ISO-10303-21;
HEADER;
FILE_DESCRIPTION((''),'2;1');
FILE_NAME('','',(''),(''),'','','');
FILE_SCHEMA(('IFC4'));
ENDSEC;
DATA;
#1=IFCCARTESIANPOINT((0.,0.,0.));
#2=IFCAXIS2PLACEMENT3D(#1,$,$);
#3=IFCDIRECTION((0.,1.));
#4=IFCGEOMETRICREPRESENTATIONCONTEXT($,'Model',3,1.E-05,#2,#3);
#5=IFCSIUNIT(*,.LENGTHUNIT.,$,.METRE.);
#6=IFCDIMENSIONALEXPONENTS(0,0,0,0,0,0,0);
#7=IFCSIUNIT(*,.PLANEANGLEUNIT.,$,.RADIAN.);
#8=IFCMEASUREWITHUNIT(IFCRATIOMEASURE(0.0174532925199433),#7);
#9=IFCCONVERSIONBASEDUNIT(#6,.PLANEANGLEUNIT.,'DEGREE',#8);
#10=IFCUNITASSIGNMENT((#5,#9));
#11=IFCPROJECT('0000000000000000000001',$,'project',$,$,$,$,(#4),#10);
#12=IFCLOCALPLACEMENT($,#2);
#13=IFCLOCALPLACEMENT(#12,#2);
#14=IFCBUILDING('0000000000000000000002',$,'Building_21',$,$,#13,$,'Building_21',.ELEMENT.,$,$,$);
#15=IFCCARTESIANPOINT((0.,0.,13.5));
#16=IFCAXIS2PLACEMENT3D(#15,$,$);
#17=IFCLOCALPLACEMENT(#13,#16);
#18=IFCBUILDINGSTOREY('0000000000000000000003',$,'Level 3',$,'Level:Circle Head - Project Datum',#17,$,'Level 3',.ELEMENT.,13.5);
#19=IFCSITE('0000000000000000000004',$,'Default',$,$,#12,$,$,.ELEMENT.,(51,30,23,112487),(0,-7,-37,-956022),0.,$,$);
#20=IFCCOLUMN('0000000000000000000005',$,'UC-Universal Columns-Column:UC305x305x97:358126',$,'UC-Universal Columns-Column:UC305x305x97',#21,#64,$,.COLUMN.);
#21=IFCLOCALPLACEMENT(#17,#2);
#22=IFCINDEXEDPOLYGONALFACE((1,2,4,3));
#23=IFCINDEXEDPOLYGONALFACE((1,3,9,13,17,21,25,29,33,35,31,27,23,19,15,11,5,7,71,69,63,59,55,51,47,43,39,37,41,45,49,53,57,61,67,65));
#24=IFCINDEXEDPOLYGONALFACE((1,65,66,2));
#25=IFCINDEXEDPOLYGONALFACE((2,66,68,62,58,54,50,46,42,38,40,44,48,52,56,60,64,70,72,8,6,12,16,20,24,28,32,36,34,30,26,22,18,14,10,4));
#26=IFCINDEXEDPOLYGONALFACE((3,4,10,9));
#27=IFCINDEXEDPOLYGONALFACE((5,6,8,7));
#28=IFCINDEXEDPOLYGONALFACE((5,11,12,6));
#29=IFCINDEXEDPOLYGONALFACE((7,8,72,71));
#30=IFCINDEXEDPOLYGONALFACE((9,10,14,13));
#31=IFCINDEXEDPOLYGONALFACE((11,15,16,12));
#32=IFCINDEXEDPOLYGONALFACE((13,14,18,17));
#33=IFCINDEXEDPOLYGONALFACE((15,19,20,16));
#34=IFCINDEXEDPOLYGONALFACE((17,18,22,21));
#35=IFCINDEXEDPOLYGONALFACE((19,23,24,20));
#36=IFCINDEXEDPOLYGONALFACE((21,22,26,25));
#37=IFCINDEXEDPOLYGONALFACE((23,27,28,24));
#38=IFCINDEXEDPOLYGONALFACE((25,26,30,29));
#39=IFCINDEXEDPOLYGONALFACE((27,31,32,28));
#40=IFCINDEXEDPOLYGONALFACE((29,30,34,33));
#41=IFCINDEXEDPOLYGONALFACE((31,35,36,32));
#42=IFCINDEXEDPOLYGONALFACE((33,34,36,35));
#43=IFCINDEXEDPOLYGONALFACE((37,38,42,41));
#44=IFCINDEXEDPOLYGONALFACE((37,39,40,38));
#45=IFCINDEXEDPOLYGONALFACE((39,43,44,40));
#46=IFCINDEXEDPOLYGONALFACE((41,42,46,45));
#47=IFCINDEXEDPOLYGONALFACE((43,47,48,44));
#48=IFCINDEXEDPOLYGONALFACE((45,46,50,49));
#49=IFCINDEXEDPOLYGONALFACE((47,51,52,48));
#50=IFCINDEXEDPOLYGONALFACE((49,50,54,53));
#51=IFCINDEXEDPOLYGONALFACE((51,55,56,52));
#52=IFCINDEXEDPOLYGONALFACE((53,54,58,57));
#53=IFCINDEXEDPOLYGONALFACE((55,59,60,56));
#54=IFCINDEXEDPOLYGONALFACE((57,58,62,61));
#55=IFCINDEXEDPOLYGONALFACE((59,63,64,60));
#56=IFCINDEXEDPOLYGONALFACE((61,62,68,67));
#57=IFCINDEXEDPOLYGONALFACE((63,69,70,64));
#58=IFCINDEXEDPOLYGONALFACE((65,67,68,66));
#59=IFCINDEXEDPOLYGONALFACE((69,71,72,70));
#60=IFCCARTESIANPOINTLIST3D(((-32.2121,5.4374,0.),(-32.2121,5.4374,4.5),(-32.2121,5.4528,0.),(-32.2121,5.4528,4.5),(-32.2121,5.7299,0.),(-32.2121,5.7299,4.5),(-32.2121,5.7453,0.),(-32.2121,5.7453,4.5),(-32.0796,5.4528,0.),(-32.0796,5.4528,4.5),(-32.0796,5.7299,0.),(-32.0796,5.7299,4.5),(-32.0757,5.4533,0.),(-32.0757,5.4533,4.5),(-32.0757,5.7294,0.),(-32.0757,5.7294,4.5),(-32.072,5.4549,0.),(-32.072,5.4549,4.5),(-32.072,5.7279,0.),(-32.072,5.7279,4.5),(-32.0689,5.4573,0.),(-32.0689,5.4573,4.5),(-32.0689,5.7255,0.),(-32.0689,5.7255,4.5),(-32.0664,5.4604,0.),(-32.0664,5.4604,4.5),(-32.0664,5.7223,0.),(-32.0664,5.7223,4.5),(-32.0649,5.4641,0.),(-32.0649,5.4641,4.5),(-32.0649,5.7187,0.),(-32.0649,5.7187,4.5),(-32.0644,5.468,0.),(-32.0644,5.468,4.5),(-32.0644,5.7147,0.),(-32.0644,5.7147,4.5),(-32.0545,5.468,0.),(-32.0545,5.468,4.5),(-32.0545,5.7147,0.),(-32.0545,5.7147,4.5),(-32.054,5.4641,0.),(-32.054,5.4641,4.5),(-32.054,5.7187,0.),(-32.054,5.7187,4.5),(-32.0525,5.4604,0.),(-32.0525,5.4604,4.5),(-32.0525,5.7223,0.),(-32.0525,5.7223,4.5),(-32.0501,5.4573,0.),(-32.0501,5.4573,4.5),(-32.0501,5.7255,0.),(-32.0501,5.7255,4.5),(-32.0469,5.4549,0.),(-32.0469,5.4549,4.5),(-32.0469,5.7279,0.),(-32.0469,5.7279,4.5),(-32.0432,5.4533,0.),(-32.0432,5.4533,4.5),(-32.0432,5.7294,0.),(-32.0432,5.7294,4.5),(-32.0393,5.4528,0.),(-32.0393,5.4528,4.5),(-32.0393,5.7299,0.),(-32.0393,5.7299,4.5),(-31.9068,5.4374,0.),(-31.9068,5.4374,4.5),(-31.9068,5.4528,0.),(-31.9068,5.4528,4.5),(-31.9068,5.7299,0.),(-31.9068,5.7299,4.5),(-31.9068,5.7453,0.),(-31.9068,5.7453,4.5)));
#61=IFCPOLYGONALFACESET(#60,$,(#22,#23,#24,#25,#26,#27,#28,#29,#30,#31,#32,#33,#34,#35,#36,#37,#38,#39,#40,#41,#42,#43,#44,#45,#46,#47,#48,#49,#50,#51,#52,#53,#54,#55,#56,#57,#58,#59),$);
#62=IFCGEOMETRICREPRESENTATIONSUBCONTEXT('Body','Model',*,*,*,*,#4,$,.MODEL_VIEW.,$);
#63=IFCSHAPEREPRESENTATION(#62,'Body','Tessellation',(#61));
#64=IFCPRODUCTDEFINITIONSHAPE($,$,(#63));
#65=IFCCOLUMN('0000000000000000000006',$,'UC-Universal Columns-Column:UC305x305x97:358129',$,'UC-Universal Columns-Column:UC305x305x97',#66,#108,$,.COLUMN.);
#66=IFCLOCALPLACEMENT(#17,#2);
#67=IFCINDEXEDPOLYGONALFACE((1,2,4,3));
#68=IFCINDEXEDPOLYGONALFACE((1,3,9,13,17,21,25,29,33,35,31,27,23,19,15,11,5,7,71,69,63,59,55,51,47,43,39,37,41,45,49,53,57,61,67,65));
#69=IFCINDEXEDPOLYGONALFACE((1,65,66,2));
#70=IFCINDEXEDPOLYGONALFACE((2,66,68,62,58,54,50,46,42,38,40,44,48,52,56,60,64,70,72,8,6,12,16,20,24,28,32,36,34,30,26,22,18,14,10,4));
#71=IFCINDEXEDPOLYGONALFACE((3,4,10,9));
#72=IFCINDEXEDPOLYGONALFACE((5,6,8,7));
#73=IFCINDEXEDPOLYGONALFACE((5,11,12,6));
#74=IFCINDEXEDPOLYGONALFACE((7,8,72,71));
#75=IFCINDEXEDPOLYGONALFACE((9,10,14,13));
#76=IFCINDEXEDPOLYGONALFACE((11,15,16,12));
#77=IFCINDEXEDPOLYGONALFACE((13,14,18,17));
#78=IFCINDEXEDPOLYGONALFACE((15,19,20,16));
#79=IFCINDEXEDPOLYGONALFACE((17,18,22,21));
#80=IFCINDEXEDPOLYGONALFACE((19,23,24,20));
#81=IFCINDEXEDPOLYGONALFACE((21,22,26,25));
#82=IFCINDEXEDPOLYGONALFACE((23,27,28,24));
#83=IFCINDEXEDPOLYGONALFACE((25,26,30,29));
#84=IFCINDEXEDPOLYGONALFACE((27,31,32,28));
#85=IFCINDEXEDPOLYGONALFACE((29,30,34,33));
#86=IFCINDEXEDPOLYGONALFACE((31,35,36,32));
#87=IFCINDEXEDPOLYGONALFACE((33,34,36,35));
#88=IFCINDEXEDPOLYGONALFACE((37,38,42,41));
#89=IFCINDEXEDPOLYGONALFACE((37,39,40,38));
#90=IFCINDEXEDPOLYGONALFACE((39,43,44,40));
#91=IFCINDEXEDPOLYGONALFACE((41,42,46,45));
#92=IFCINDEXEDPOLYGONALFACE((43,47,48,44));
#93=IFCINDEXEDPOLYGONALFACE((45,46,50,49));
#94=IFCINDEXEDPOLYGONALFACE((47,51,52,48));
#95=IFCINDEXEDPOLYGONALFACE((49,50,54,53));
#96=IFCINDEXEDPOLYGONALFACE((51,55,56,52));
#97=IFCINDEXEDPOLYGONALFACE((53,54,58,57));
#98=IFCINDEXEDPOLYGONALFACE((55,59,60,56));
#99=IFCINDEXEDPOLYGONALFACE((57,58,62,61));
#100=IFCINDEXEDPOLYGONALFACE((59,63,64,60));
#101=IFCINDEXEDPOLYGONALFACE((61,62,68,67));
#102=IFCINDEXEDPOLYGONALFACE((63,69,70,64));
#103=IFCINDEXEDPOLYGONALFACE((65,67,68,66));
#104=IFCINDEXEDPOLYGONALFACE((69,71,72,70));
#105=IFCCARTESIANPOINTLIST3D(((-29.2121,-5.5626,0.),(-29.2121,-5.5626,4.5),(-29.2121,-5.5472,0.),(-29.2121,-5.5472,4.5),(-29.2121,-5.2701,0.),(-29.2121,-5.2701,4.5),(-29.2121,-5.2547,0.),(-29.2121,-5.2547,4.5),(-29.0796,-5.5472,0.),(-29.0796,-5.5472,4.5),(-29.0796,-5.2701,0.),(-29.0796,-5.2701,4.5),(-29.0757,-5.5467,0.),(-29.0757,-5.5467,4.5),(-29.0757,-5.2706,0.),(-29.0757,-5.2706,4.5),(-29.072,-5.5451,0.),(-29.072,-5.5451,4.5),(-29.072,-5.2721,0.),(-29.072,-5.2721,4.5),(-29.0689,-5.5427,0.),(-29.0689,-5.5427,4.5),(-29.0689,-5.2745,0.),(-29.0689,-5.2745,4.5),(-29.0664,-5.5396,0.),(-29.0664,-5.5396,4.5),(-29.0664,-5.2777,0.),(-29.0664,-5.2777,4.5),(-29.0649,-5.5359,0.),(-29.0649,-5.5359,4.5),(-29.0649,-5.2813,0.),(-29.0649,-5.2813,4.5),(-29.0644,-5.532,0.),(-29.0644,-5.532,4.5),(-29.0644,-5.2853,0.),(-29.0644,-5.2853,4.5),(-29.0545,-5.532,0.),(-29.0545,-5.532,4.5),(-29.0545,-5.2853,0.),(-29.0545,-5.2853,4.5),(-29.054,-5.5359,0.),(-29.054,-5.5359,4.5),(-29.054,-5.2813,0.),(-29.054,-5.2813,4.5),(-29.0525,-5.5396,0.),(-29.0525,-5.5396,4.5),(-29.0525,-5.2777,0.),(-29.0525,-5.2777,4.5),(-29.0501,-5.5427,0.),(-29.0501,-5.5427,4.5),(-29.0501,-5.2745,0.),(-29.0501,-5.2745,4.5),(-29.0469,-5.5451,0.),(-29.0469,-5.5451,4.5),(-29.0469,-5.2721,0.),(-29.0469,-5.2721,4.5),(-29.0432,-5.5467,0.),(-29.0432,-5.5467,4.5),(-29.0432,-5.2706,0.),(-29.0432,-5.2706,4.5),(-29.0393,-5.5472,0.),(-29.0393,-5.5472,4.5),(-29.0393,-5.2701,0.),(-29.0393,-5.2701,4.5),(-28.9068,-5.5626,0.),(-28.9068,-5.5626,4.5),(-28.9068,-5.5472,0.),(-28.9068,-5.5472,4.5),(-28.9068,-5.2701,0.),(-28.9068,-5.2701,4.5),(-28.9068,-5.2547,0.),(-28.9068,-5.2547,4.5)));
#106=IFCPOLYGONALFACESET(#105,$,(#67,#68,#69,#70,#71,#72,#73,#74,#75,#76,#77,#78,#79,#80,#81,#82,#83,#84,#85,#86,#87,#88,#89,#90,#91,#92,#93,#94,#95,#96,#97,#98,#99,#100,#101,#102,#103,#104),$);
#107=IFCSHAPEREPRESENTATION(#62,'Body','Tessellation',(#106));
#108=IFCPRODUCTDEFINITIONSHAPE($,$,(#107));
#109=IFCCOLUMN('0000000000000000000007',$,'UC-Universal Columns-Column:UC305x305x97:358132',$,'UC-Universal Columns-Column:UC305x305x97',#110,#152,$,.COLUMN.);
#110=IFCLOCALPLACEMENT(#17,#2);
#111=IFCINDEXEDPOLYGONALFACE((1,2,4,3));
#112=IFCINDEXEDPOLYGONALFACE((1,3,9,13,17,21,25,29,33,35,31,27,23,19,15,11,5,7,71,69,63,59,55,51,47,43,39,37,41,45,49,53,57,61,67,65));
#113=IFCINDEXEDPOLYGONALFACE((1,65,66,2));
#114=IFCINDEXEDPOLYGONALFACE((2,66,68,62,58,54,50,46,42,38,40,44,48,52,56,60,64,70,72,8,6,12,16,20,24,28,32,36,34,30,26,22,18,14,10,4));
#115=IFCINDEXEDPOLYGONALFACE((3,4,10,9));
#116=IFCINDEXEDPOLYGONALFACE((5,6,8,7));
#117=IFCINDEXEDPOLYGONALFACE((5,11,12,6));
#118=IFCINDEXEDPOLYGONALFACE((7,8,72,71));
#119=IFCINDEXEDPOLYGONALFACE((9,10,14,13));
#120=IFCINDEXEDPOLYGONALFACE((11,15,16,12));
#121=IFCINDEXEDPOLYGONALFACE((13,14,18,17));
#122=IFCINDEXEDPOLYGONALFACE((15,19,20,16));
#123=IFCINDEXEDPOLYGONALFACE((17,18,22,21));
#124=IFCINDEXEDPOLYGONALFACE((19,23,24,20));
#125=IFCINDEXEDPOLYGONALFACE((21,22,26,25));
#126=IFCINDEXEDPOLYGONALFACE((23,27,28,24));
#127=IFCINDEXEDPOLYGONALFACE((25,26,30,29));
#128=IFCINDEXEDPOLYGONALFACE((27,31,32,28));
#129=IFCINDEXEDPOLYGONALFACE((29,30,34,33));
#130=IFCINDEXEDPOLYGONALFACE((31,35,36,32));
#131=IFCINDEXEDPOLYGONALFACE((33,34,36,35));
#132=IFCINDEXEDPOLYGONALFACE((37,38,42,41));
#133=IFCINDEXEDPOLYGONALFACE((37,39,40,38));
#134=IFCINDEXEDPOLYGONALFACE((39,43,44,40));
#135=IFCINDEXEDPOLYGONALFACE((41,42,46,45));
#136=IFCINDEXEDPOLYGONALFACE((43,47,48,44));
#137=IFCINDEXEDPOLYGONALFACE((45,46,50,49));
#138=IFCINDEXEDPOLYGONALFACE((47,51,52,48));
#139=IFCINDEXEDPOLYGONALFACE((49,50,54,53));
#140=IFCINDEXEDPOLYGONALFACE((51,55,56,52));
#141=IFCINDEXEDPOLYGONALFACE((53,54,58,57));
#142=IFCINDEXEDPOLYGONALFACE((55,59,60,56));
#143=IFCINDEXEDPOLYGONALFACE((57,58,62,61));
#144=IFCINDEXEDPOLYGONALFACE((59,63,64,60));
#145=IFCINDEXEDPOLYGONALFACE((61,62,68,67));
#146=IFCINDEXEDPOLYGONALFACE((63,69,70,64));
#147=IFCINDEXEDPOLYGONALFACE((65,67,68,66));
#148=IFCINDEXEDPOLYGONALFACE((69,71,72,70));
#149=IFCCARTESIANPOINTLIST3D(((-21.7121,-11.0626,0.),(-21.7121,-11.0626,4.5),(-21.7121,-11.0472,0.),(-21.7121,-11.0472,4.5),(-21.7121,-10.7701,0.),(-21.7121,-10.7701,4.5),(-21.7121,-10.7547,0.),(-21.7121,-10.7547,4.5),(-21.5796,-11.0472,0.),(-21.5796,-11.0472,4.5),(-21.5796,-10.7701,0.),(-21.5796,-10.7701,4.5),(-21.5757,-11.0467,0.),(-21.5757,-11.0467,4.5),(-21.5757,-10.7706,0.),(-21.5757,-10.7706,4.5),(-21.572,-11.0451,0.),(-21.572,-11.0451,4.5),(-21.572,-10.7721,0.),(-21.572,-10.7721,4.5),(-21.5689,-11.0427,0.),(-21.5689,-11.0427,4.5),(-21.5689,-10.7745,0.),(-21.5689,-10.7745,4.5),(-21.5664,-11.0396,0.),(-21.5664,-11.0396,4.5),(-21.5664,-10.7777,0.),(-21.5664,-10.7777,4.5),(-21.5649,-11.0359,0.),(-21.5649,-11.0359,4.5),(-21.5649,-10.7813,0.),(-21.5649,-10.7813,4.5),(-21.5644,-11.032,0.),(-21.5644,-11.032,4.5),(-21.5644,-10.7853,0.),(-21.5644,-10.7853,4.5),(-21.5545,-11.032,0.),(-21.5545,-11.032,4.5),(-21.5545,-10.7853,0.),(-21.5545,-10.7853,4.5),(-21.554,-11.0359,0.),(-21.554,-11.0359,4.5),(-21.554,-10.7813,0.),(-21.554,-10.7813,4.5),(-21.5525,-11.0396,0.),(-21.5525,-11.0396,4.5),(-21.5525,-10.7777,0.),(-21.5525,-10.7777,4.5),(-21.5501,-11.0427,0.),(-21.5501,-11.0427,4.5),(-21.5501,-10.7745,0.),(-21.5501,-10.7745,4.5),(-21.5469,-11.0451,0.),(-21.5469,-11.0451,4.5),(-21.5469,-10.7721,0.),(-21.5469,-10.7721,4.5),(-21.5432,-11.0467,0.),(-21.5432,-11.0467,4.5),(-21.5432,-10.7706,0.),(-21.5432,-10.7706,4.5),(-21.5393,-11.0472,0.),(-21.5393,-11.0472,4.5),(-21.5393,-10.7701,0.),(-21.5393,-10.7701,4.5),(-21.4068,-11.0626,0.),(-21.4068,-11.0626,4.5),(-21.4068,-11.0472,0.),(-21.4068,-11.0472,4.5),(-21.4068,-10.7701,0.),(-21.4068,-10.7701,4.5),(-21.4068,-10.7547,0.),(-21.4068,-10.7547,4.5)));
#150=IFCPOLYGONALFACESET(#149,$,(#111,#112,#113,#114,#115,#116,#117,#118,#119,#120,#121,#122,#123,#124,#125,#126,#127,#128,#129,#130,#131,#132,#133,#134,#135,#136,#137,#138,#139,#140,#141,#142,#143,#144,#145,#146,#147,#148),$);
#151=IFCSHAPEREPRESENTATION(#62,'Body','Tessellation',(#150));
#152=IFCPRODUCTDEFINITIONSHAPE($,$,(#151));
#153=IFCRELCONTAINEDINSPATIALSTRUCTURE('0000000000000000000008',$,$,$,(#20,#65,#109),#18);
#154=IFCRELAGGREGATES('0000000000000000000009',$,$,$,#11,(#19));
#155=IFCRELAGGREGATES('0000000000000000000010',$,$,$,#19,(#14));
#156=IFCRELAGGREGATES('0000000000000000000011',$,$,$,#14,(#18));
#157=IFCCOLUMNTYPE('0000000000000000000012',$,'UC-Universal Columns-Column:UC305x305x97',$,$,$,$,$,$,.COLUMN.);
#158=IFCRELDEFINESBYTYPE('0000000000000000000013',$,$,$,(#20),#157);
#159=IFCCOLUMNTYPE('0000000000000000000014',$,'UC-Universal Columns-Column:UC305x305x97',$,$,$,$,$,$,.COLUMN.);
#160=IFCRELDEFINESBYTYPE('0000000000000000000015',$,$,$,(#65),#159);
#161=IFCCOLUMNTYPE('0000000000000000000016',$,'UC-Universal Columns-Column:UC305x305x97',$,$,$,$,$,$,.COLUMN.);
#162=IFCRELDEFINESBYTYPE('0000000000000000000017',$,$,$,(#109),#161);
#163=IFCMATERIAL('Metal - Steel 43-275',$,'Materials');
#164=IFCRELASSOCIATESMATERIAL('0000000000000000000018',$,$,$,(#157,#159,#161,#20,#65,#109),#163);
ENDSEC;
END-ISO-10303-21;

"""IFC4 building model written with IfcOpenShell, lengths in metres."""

from ifc_helpers import new_model, entity, si_unit, converted_unit, direction, frame, frame_2d, origin, place, context, subcontext, project, spatial, polyline, circle_curve, parameter, trimmed, segment, composite_curve, i_section, outline, extrude, source, transform, mapped, material, material_profile, profile_set, profile_usage, type_object, type_shapes, element, save


model = new_model("IFC4")

# Units and contexts
model_context = context("Model", 3, precision=1e-05, world=origin(), true_north=direction((0.0, 1.0)))
body_context = subcontext(model_context, "Body", "Model", "MODEL_VIEW")
ifc_project = project(units=[si_unit("LENGTHUNIT", "METRE"), converted_unit("PLANEANGLEUNIT", "DEGREE", entity("IfcRatioMeasure", 0.0174532925199433), si_unit("PLANEANGLEUNIT", "RADIAN"), dimensions=[0, 0, 0, 0, 0, 0, 0])], contexts=[model_context])

# Site, building, storey
site_placement = place(None, origin())
site = spatial("IfcSite", under=ifc_project, at=site_placement, Name="Default", CompositionType="ELEMENT", RefLatitude=(51, 30, 23, 112487), RefLongitude=(0, -7, -37, -956022), RefElevation=0.0)
building_placement = place(site_placement, origin())
building = spatial("IfcBuilding", under=site, at=building_placement, Name="Building_21", LongName="Building_21", CompositionType="ELEMENT")
storey_placement = place(building_placement, frame((0.0, 0.0, 13.5)))
storey = spatial("IfcBuildingStorey", under=building, at=storey_placement, Name="Level 3", ObjectType="Level:Circle Head - Project Datum", LongName="Level 3", CompositionType="ELEMENT", Elevation=13.5)

# Columns
ifc_material_1 = material(Name="Metal - Steel 43-275", Category="Materials")
ifc_material_profile_1 = material_profile(ifc_material_1, outline(composite_curve([segment(polyline([(-0.1527, 0.154, 0.0), (0.1527, 0.154, 0.0)]), True, "CONTINUOUS"), segment(polyline([(0.1527, 0.154, 0.0), (0.1527, 0.1386, 0.0)]), True, "CONTINUOUS"), segment(polyline([(0.1527, 0.1386, 0.0), (0.0201, 0.1386, 0.0)]), True, "CONTINUOUS"), segment(trimmed(circle_curve(frame((0.0201, 0.1234, 0.0)), 0.0152), [parameter(90.0)], [parameter(180.0)], True, "PARAMETER"), True, "CONTINUOUS"), segment(polyline([(0.0049, 0.1234, 0.0), (0.0049, -0.1234, 0.0)]), True, "CONTINUOUS"), segment(trimmed(circle_curve(frame((0.0201, -0.1234, 0.0)), 0.0152), [parameter(180.0)], [parameter(270.0)], True, "PARAMETER"), True, "CONTINUOUS"), segment(polyline([(0.0201, -0.1386, 0.0), (0.1527, -0.1386, 0.0)]), True, "CONTINUOUS"), segment(polyline([(0.1527, -0.1386, 0.0), (0.1527, -0.154, 0.0)]), True, "CONTINUOUS"), segment(polyline([(0.1527, -0.154, 0.0), (-0.1527, -0.154, 0.0)]), True, "CONTINUOUS"), segment(polyline([(-0.1527, -0.154, 0.0), (-0.1527, -0.1386, 0.0)]), True, "CONTINUOUS"), segment(polyline([(-0.1527, -0.1386, 0.0), (-0.0201, -0.1386, 0.0)]), True, "CONTINUOUS"), segment(trimmed(circle_curve(frame((-0.0201, -0.1234, 0.0)), 0.0152), [parameter(270.0)], [parameter(0.0)], True, "PARAMETER"), True, "CONTINUOUS"), segment(polyline([(-0.0049, -0.1234, 0.0), (-0.005, 0.1234, 0.0)]), True, "CONTINUOUS"), segment(trimmed(circle_curve(frame((-0.0201, 0.1234, 0.0)), 0.0152), [parameter(0.0)], [parameter(90.0)], True, "PARAMETER"), True, "CONTINUOUS"), segment(polyline([(-0.0201, 0.1386, 0.0), (-0.1527, 0.1386, 0.0)]), True, "CONTINUOUS"), segment(polyline([(-0.1527, 0.1386, 0.0), (-0.1527, 0.154, 0.0)]), True, "CONTINUOUS")], self_intersect=False), kind="CURVE"), Name="UC305x305x97")
ifc_material_profile_2 = material_profile(ifc_material_1, outline(composite_curve([segment(polyline([(0.1527, 0.154, 0.0), (0.1527, 0.1386, 0.0)]), True, "CONTINUOUS"), segment(polyline([(0.1527, 0.1386, 0.0), (0.0049, 0.1386, 0.0)]), True, "CONTINUOUS"), segment(polyline([(0.0049, 0.1386, 0.0), (0.0049, -0.1386, 0.0)]), True, "CONTINUOUS"), segment(polyline([(0.0049, -0.1386, 0.0), (0.1527, -0.1386, 0.0)]), True, "CONTINUOUS"), segment(polyline([(0.1527, -0.1386, 0.0), (0.1527, -0.154, 0.0)]), True, "CONTINUOUS"), segment(polyline([(0.1527, -0.154, 0.0), (-0.1527, -0.154, 0.0)]), True, "CONTINUOUS"), segment(polyline([(-0.1527, -0.154, 0.0), (-0.1527, -0.1386, 0.0)]), True, "CONTINUOUS"), segment(polyline([(-0.1527, -0.1386, 0.0), (-0.005, -0.1386, 0.0)]), True, "CONTINUOUS"), segment(polyline([(-0.005, -0.1386, 0.0), (-0.005, 0.1386, 0.0)]), True, "CONTINUOUS"), segment(polyline([(-0.005, 0.1386, 0.0), (-0.1527, 0.1386, 0.0)]), True, "CONTINUOUS"), segment(polyline([(-0.1527, 0.1386, 0.0), (-0.1527, 0.154, 0.0)]), True, "CONTINUOUS"), segment(polyline([(-0.1527, 0.154, 0.0), (0.1527, 0.154, 0.0)]), True, "CONTINUOUS")], self_intersect=False), kind="CURVE"), Name="UC305x305x97")
ifc_profile_set = profile_set([ifc_material_profile_1, ifc_material_profile_2], Name="UC305x305x97")
ifc_profile_usage_1 = profile_usage(ifc_profile_set)
column_type_1 = type_object("IfcColumnType", Name="UC-Universal Columns-Column:UC305x305x97", PredefinedType="COLUMN", material=ifc_profile_set)
shared_shape_1 = source(origin(), body_context, "Body", "SweptSolid", [
    extrude(i_section(OverallWidth=0.3053, OverallDepth=0.3079, WebThickness=0.0099, FlangeThickness=0.0154, FilletRadius=0.0152, at=frame_2d((0.0, 0.0), x_axis=(0.0, 1.0))), frame((-32.0595, 5.5914, 13.5), z_axis=(0.0, 0.0, 1.0), x_axis=(0.0, -1.0, 0.0)), (0.0, 0.0, 1.0), 4.5),
])
type_shapes(column_type_1, [shared_shape_1])
column_1_placement = place(storey_placement, frame((0.0, 0.0, -13.5)))
element("IfcColumn", 1, at=column_1_placement, inside=storey, type_object=column_type_1, material=ifc_profile_usage_1, Name="UC-Universal Columns-Column:UC305x305x97:358126", ObjectType="UC-Universal Columns-Column:UC305x305x97", PredefinedType="COLUMN", context=body_context, shape_type="MappedRepresentation", body=[
    mapped(shared_shape_1, transform((0.0, 0.0, 0.0), scale=1.0)),
])
ifc_profile_usage_2 = profile_usage(ifc_profile_set)
column_type_2 = type_object("IfcColumnType", Name="UC-Universal Columns-Column:UC305x305x97", PredefinedType="COLUMN", material=ifc_profile_set)
shared_shape_2 = source(origin(), body_context, "Body", "SweptSolid", [
    extrude(i_section(OverallWidth=0.3053, OverallDepth=0.3079, WebThickness=0.0099, FlangeThickness=0.0154, FilletRadius=0.0152, at=frame_2d((0.0, 0.0), x_axis=(0.0, 1.0))), frame((-29.0595, -5.4086, 13.5), z_axis=(0.0, 0.0, 1.0), x_axis=(0.0, -1.0, 0.0)), (0.0, 0.0, 1.0), 4.5),
])
type_shapes(column_type_2, [shared_shape_2])
column_2_placement = place(storey_placement, frame((0.0, 0.0, -13.5)))
element("IfcColumn", 2, at=column_2_placement, inside=storey, type_object=column_type_2, material=ifc_profile_usage_2, Name="UC-Universal Columns-Column:UC305x305x97:358129", ObjectType="UC-Universal Columns-Column:UC305x305x97", PredefinedType="COLUMN", context=body_context, shape_type="MappedRepresentation", body=[
    mapped(shared_shape_2, transform((0.0, 0.0, 0.0), scale=1.0)),
])
ifc_profile_usage_3 = profile_usage(ifc_profile_set)
column_type_3 = type_object("IfcColumnType", Name="UC-Universal Columns-Column:UC305x305x97", PredefinedType="COLUMN", material=ifc_profile_set)
shared_shape_3 = source(origin(), body_context, "Body", "SweptSolid", [
    extrude(i_section(OverallWidth=0.3053, OverallDepth=0.3079, WebThickness=0.0099, FlangeThickness=0.0154, FilletRadius=0.0152, at=frame_2d((0.0, 0.0), x_axis=(0.0, 1.0))), frame((-21.5595, -10.9086, 13.5), z_axis=(0.0, 0.0, 1.0), x_axis=(0.0, -1.0, 0.0)), (0.0, 0.0, 1.0), 4.5),
])
type_shapes(column_type_3, [shared_shape_3])
column_3_placement = place(storey_placement, frame((0.0, 0.0, -13.5)))
element("IfcColumn", 3, at=column_3_placement, inside=storey, type_object=column_type_3, material=ifc_profile_usage_3, Name="UC-Universal Columns-Column:UC305x305x97:358132", ObjectType="UC-Universal Columns-Column:UC305x305x97", PredefinedType="COLUMN", context=body_context, shape_type="MappedRepresentation", body=[
    mapped(shared_shape_3, transform((0.0, 0.0, 0.0), scale=1.0)),
])

save(model, "model.ifc")
